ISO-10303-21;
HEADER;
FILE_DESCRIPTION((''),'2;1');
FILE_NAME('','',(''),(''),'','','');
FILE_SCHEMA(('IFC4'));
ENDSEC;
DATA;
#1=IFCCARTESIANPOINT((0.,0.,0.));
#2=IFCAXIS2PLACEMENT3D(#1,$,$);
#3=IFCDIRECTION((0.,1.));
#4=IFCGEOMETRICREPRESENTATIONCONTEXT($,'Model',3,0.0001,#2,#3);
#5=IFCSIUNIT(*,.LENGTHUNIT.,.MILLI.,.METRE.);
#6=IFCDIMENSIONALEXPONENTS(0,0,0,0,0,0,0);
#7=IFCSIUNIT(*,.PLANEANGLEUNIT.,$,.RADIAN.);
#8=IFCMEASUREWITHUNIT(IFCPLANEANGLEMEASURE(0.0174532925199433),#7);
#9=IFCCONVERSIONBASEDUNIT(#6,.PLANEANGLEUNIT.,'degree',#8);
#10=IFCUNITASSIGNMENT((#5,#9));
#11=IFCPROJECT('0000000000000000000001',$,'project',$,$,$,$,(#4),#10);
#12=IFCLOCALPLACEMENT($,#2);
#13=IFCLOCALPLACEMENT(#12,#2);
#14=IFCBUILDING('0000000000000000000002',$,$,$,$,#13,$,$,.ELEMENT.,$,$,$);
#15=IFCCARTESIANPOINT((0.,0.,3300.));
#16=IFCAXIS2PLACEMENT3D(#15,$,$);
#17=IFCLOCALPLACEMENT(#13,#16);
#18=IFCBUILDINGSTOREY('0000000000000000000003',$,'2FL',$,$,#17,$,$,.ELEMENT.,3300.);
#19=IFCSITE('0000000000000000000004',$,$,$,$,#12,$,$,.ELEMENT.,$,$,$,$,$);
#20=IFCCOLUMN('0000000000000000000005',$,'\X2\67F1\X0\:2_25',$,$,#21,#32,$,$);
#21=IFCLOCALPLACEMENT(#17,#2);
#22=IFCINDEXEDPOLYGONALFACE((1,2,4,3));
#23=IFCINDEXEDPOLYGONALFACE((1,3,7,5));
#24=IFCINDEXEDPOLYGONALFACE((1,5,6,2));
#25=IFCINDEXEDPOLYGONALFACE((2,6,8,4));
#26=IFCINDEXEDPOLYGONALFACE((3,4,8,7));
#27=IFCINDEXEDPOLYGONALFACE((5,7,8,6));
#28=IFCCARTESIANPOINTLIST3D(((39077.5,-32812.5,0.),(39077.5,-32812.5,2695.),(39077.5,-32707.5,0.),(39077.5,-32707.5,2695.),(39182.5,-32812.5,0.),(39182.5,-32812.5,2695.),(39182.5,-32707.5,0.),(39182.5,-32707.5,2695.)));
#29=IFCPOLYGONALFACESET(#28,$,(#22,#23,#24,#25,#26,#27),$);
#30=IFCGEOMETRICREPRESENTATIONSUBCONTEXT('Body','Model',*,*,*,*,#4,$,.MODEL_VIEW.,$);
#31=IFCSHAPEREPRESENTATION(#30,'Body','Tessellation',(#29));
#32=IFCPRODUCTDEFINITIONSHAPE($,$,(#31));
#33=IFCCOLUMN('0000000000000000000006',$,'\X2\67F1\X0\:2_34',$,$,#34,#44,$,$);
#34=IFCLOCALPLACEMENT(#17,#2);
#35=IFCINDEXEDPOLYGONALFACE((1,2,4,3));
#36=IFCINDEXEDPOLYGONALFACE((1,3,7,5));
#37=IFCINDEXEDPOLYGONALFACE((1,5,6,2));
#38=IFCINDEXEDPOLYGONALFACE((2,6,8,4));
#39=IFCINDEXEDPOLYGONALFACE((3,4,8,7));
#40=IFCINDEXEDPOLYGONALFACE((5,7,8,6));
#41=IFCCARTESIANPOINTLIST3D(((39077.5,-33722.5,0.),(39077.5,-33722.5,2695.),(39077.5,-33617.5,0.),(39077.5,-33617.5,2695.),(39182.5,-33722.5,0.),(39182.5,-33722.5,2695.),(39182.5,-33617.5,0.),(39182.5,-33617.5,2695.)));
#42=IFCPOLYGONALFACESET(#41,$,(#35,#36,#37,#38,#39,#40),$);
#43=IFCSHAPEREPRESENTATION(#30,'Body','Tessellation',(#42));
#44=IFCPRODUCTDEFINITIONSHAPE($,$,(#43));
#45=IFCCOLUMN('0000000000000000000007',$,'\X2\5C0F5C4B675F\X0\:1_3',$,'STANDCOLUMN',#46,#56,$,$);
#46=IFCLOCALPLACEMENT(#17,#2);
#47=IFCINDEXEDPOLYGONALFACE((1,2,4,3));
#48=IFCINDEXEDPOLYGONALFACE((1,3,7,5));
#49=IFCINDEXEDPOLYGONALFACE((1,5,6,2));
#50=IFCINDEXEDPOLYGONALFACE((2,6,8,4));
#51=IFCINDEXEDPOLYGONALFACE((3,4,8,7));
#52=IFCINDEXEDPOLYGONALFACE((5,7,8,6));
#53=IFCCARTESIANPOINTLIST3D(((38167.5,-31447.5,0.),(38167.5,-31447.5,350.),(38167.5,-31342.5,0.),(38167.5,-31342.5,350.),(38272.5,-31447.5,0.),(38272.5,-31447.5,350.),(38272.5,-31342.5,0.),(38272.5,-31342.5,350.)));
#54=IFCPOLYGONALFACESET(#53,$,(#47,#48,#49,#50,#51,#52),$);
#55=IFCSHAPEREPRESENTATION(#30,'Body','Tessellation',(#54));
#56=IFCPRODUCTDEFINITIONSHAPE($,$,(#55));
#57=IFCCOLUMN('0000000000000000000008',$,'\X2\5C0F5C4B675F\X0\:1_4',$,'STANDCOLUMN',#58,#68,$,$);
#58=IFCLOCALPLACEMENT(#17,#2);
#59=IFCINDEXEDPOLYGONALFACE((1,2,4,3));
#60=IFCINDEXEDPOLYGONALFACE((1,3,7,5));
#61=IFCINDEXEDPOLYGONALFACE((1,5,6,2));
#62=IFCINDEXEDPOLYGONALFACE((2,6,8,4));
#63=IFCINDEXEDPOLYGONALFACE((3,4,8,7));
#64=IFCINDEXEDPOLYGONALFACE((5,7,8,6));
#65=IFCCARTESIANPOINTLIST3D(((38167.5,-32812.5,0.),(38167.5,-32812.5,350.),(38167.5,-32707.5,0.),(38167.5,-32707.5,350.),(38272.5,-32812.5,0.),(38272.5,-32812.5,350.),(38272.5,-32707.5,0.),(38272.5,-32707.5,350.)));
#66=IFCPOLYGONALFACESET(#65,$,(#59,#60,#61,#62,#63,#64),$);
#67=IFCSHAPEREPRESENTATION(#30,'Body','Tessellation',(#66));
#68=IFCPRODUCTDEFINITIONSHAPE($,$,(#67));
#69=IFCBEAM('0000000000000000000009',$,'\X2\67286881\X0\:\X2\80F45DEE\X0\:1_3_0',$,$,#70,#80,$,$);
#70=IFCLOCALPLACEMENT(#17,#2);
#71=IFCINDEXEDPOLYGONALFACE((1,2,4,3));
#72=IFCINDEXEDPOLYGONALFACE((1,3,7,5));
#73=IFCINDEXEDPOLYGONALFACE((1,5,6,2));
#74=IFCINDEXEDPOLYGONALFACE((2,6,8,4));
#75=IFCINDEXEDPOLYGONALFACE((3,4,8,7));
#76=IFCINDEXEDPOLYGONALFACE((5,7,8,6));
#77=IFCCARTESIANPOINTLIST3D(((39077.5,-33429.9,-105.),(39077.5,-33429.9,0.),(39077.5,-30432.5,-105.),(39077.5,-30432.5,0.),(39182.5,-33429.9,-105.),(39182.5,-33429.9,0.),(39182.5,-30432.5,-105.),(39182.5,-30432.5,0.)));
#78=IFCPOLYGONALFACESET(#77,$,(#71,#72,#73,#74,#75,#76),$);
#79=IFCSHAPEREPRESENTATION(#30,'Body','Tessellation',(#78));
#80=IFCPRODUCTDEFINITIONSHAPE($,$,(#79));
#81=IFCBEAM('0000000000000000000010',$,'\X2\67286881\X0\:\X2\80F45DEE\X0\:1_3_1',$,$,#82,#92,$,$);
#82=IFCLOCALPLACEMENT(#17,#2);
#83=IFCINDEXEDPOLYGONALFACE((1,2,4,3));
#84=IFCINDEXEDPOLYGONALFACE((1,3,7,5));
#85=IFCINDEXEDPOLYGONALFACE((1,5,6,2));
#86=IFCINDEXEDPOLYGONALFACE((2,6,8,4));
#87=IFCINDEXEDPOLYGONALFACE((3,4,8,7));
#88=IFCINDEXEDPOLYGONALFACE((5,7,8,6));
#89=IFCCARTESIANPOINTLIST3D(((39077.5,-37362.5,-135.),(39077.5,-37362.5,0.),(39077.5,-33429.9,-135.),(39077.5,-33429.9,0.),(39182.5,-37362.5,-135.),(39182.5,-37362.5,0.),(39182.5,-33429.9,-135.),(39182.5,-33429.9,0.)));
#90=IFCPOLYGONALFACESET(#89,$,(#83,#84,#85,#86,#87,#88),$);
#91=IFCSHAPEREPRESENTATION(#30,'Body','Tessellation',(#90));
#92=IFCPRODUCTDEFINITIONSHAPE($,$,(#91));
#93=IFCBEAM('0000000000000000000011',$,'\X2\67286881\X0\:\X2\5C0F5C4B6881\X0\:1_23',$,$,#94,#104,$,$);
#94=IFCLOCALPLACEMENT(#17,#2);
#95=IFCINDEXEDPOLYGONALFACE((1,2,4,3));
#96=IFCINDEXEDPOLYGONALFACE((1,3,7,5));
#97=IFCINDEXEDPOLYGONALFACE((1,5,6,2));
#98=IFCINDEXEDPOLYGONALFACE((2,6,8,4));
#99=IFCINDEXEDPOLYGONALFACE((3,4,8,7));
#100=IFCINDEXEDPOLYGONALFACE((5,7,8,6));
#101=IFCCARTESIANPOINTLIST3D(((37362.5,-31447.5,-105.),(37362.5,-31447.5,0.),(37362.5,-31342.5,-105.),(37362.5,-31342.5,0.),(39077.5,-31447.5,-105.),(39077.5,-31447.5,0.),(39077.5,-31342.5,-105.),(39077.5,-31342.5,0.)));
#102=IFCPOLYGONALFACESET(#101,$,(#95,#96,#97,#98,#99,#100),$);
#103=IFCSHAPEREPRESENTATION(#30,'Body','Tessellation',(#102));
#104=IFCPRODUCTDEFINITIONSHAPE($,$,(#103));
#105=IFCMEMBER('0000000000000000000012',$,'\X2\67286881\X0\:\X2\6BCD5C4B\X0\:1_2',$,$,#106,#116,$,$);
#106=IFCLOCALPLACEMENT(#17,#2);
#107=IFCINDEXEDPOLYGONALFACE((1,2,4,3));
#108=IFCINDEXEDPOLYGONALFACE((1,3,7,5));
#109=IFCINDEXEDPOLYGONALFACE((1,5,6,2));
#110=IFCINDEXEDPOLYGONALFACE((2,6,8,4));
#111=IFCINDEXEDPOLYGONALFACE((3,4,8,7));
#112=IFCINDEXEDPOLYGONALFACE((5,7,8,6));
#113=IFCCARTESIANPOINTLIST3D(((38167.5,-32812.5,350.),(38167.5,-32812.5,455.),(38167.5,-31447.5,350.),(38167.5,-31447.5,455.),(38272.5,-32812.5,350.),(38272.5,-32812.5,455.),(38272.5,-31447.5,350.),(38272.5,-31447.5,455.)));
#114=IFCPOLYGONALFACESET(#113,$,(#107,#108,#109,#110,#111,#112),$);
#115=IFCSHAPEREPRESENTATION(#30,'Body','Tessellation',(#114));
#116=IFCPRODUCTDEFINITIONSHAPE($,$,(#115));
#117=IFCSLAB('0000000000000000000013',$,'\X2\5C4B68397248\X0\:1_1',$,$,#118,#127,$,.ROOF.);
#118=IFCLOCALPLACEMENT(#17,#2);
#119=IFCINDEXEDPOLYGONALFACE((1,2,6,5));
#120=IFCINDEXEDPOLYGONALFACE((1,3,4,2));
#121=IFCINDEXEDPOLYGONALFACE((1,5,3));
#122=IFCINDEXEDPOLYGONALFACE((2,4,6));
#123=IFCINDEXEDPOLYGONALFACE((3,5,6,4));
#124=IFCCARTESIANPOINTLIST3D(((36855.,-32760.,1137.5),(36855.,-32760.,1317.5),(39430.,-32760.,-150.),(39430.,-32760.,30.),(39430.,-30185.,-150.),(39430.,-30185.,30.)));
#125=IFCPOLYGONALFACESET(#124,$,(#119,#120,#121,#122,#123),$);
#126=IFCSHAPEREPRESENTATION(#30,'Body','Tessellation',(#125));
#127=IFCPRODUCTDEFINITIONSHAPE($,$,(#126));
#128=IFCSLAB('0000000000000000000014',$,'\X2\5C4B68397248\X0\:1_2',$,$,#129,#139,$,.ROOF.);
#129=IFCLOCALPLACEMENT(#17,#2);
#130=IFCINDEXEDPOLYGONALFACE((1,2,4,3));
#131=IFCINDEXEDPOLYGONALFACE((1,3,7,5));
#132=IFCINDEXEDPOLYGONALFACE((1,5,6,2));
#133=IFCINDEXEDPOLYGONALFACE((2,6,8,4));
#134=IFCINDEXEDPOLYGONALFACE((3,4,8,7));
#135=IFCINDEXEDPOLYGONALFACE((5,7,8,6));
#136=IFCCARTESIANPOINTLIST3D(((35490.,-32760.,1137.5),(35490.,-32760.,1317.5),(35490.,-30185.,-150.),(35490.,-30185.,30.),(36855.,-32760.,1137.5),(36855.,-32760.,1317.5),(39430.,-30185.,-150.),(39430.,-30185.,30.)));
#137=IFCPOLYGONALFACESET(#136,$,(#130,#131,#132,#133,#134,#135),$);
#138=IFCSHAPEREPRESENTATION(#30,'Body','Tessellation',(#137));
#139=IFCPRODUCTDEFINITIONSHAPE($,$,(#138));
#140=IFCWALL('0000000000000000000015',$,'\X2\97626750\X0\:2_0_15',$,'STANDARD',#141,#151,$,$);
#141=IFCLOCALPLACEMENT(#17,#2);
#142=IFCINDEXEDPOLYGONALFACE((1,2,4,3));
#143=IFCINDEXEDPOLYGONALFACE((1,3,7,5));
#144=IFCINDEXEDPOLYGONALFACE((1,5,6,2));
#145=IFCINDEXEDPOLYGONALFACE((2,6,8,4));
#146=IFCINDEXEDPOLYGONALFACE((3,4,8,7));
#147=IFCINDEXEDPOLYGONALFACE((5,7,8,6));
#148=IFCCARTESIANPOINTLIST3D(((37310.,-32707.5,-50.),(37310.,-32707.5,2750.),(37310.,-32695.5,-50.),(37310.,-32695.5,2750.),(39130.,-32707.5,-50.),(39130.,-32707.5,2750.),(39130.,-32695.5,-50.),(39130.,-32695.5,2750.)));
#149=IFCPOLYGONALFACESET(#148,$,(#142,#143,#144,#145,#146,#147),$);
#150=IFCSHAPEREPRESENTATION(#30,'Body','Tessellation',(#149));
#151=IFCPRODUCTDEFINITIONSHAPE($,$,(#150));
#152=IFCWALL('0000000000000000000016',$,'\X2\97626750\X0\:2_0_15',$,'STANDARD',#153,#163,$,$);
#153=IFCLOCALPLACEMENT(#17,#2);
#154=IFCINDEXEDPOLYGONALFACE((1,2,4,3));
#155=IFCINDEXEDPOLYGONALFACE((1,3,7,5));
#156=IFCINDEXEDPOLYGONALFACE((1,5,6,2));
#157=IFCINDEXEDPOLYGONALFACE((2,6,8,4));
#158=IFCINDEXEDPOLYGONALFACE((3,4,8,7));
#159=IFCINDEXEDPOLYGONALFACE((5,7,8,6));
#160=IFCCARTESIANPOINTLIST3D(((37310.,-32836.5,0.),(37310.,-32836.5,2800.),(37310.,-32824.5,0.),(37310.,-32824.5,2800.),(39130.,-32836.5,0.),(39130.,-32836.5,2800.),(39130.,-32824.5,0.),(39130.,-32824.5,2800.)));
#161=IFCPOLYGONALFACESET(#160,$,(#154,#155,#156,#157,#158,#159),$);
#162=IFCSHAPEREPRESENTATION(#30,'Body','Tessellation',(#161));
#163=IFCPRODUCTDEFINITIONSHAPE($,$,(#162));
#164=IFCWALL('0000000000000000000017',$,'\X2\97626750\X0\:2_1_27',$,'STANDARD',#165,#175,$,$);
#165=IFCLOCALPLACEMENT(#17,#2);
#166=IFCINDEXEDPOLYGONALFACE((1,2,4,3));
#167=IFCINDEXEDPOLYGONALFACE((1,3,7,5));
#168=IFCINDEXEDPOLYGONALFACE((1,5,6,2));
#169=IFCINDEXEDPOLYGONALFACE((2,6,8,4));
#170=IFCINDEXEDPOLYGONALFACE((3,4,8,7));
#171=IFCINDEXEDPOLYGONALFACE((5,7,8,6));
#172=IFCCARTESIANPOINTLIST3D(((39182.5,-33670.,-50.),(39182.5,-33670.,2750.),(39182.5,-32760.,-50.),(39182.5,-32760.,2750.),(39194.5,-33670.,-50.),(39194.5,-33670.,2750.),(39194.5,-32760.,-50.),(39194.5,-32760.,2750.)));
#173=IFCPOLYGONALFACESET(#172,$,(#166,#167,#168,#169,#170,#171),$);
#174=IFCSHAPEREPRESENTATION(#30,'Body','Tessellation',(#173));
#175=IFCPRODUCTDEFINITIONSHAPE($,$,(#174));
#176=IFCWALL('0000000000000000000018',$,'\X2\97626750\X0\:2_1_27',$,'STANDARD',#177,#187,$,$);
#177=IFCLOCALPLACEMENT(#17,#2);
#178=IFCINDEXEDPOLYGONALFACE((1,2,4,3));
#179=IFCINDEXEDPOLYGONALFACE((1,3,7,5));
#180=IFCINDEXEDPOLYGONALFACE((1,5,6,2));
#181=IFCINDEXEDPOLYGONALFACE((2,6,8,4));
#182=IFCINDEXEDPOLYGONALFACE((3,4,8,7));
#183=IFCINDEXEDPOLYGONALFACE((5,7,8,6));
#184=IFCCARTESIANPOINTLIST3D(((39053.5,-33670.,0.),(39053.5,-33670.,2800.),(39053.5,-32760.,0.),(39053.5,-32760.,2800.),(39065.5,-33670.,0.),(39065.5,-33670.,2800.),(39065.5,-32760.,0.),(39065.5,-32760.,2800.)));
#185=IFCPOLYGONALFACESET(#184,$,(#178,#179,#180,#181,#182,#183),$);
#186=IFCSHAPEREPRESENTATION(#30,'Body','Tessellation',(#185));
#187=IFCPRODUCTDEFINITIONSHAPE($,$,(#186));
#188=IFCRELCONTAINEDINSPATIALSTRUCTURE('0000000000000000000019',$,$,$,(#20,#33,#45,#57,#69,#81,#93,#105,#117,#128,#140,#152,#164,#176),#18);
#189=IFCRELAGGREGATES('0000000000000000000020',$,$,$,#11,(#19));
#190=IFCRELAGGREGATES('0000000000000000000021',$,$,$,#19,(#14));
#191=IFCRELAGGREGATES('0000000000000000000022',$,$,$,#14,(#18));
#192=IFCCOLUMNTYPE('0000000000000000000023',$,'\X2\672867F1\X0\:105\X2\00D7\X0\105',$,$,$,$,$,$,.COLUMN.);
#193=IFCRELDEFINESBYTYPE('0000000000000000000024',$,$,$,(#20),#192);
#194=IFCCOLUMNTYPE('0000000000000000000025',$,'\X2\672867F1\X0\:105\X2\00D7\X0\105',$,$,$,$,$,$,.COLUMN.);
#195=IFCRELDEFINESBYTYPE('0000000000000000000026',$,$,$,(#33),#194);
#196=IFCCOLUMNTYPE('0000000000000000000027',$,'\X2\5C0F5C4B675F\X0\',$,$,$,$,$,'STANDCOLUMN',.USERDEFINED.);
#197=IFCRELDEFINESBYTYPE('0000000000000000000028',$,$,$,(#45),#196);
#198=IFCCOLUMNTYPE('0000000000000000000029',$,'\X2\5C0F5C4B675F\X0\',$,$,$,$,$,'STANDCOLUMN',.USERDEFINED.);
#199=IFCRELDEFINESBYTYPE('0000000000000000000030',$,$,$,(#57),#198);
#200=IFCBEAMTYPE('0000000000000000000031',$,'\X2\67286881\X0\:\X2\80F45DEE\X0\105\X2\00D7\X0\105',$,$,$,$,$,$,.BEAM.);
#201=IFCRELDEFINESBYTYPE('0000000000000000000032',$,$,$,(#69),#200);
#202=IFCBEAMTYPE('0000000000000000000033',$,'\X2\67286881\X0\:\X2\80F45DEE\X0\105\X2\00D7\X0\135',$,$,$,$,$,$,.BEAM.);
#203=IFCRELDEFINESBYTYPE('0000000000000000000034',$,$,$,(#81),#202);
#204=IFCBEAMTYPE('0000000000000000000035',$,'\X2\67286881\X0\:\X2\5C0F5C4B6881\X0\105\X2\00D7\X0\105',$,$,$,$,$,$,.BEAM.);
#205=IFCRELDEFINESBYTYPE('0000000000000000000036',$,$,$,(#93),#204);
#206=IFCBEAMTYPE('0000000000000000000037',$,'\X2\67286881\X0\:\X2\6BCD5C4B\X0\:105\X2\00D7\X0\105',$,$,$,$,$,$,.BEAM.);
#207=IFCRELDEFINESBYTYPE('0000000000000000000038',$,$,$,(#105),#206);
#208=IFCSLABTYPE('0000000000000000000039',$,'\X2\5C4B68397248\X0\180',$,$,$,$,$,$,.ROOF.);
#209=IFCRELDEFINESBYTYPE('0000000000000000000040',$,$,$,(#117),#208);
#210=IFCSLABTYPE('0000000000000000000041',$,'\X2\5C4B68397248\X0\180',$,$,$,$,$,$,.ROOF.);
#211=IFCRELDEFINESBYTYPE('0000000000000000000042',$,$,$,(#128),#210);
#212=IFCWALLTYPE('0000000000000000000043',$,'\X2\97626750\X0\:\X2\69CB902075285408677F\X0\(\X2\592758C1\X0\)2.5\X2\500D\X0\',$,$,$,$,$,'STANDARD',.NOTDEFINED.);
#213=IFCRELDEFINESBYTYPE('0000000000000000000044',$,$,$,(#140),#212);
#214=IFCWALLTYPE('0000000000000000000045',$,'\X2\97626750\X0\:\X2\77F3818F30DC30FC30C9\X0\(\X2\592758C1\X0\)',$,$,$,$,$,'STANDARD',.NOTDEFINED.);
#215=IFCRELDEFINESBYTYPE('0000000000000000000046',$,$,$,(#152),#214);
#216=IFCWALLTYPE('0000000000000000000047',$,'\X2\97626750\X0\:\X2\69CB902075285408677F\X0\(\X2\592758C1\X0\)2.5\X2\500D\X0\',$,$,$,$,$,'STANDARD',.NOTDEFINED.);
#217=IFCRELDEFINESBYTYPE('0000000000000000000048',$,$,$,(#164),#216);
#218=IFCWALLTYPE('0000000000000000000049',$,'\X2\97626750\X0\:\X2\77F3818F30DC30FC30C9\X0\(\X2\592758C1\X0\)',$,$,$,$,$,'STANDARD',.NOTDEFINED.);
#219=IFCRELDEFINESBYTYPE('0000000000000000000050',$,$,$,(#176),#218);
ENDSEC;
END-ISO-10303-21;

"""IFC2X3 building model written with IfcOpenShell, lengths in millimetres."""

from ifc_helpers import new_model, entity, si_unit, converted_unit, direction, frame, origin, origin_with_axes, origin_2d, place, context, subcontext, project, spatial, polyline, rectangle, outline, extrude, type_object, element, save


model = new_model("IFC2X3")

# Units and contexts
model_context = context("Model", 3, precision=0.0001, world=origin(), true_north=direction((0.0, 1.0)))
body_context = subcontext(model_context, "Body", "Model", "MODEL_VIEW")
ifc_project = project(units=[si_unit("LENGTHUNIT", "METRE", prefix="MILLI"), converted_unit("PLANEANGLEUNIT", "degree", entity("IfcPlaneAngleMeasure", 0.0174532925199433), si_unit("PLANEANGLEUNIT", "RADIAN"), dimensions=[0, 0, 0, 0, 0, 0, 0])], contexts=[model_context])

# Site, building, storey
site_placement = place(None, origin())
site = spatial("IfcSite", under=ifc_project, at=site_placement, CompositionType="ELEMENT")
building_placement = place(site_placement, origin())
building = spatial("IfcBuilding", under=site, at=building_placement, CompositionType="ELEMENT")
storey_placement = place(building_placement, frame((0.0, 0.0, 3300.0)))
storey = spatial("IfcBuildingStorey", under=building, at=storey_placement, Name="2FL", CompositionType="ELEMENT", Elevation=3300.0)

# Columns
column_type_1 = type_object("IfcColumnType", Name="木柱:105×105", PredefinedType="COLUMN")
column_1_placement = place(storey_placement, frame((39130.0, -32760.0, 0.0)))
element("IfcColumn", 1, at=column_1_placement, inside=storey, type_object=column_type_1, Name="柱:2_25", context=body_context, shape_type="SweptSolid", body=[
    extrude(rectangle(XDim=105.0, YDim=105.0, at=origin_2d()), origin_with_axes(), (0.0, 0.0, 1.0), 2695.0),
])
column_type_2 = type_object("IfcColumnType", Name="木柱:105×105", PredefinedType="COLUMN")
column_2_placement = place(storey_placement, frame((39130.0, -33670.0, 0.0)))
element("IfcColumn", 2, at=column_2_placement, inside=storey, type_object=column_type_2, Name="柱:2_34", context=body_context, shape_type="SweptSolid", body=[
    extrude(rectangle(XDim=105.0, YDim=105.0, at=origin_2d()), origin_with_axes(), (0.0, 0.0, 1.0), 2695.0),
])
column_type_3 = type_object("IfcColumnType", Name="小屋束", ElementType="STANDCOLUMN", PredefinedType="USERDEFINED")
column_3_placement = place(storey_placement, frame((38220.0, -31395.0, 0.0)))
element("IfcColumn", 3, at=column_3_placement, inside=storey, type_object=column_type_3, Name="小屋束:1_3", ObjectType="STANDCOLUMN", context=body_context, shape_type="SweptSolid", body=[
    extrude(rectangle(XDim=105.0, YDim=105.0, at=origin_2d()), origin_with_axes(), (0.0, 0.0, 1.0), 350.0),
])
column_type_4 = type_object("IfcColumnType", Name="小屋束", ElementType="STANDCOLUMN", PredefinedType="USERDEFINED")
column_4_placement = place(storey_placement, frame((38220.0, -32760.0, 0.0)))
element("IfcColumn", 4, at=column_4_placement, inside=storey, type_object=column_type_4, Name="小屋束:1_4", ObjectType="STANDCOLUMN", context=body_context, shape_type="SweptSolid", body=[
    extrude(rectangle(XDim=105.0, YDim=105.0, at=origin_2d()), origin_with_axes(), (0.0, 0.0, 1.0), 350.0),
])

# Beams
beam_type_1 = type_object("IfcBeamType", Name="木梁:胴差105×105", PredefinedType="BEAM")
beam_1_placement = place(storey_placement, frame((39130.0, -30432.5, -52.5), z_axis=(0.0, -1.0, 0.0), x_axis=(1.0, 0.0, 0.0)))
element("IfcBeam", 5, at=beam_1_placement, inside=storey, type_object=beam_type_1, Name="木梁:胴差:1_3_0", context=body_context, shape_type="SweptSolid", body=[
    extrude(rectangle(XDim=105.0, YDim=105.0, at=origin_2d()), origin_with_axes(), (0.0, 0.0, 1.0), 2997.4),
])
beam_type_2 = type_object("IfcBeamType", Name="木梁:胴差105×135", PredefinedType="BEAM")
beam_2_placement = place(storey_placement, frame((39130.0, -33429.9, -67.5), z_axis=(0.0, -1.0, 0.0), x_axis=(1.0, 0.0, 0.0)))
element("IfcBeam", 6, at=beam_2_placement, inside=storey, type_object=beam_type_2, Name="木梁:胴差:1_3_1", context=body_context, shape_type="SweptSolid", body=[
    extrude(rectangle(XDim=105.0, YDim=135.0, at=origin_2d()), origin_with_axes(), (0.0, 0.0, 1.0), 3932.6),
])
beam_type_3 = type_object("IfcBeamType", Name="木梁:小屋梁105×105", PredefinedType="BEAM")
beam_3_placement = place(storey_placement, frame((37362.5, -31395.0, -52.5), z_axis=(1.0, 0.0, 0.0), x_axis=(0.0, 1.0, 0.0)))
element("IfcBeam", 7, at=beam_3_placement, inside=storey, type_object=beam_type_3, Name="木梁:小屋梁:1_23", context=body_context, shape_type="SweptSolid", body=[
    extrude(rectangle(XDim=105.0, YDim=105.0, at=origin_2d()), origin_with_axes(), (0.0, 0.0, 1.0), 1715.0),
])

# Member
beam_type_4 = type_object("IfcBeamType", Name="木梁:母屋:105×105", PredefinedType="BEAM")
member_1_placement = place(storey_placement, frame((38220.0, -31447.5, 402.5), z_axis=(0.0, -1.0, 0.0), x_axis=(-1.0, 0.0, 0.0)))
element("IfcMember", 8, at=member_1_placement, inside=storey, type_object=beam_type_4, Name="木梁:母屋:1_2", context=body_context, shape_type="SweptSolid", body=[
    extrude(rectangle(XDim=105.0, YDim=105.0, at=origin_2d()), origin_with_axes(), (0.0, 0.0, 1.0), 1365.0),
])

# Slabs
slab_type_1 = type_object("IfcSlabType", Name="屋根版180", PredefinedType="ROOF")
slab_1_placement = place(storey_placement, frame((39430.0, -32760.0, -150.0), z_axis=(0.447214, 0.0, 0.894427), x_axis=(0.0, 1.0, 0.0)))
element("IfcSlab", 9, at=slab_1_placement, inside=storey, type_object=slab_type_1, Name="屋根版:1_1", PredefinedType="ROOF", context=body_context, shape_type="SweptSolid", body=[
    extrude(outline(polyline([(0.0, 0.0, 0.0), (2575.0, 0.0, 0.0), (0.0, 2878.9, 0.0), (0.0, 0.0, 0.0)])), origin_with_axes(), (0.0, 0.447214, 0.894427), 180.0),
])
slab_type_2 = type_object("IfcSlabType", Name="屋根版180", PredefinedType="ROOF")
slab_2_placement = place(storey_placement, frame((39430.0, -30185.0, -150.0), z_axis=(0.0, -0.447214, -0.894427), x_axis=(-0.666667, -0.666667, 0.333333)))
element("IfcSlab", 10, at=slab_2_placement, inside=storey, type_object=slab_type_2, Name="屋根版:1_2", PredefinedType="ROOF", context=body_context, shape_type="SweptSolid", body=[
    extrude(outline(polyline([(0.0, 0.0, 0.0), (3862.5, 0.0, 0.0), (4772.5, 1017.4, 0.0), (2626.7, 2936.7, 0.0), (0.0, 0.0, 0.0)])), origin_with_axes(), (0.333333, -0.298142, -0.894427), 180.0),
])

# Walls
wall_type_1 = type_object("IfcWallType", Name="面材:構造用合板(大壁)2.5倍", ElementType="STANDARD", PredefinedType="NOTDEFINED")
wall_1_placement = place(storey_placement, frame((38220.0, -32695.5, -50.0), z_axis=(0.0, -1.0, 0.0), x_axis=(1.0, 0.0, 0.0)))
element("IfcWall", 11, at=wall_1_placement, inside=storey, type_object=wall_type_1, Name="面材:2_0_15", ObjectType="STANDARD", context=body_context, shape_type="SweptSolid", body=[
    extrude(outline(polyline([(910.0, 0.0, 0.0), (-910.0, 0.0, 0.0), (-910.0, 2800.0, 0.0), (910.0, 2800.0, 0.0), (910.0, 0.0, 0.0)])), origin_with_axes(), (0.0, 0.0, 1.0), 12.0),
])
wall_type_2 = type_object("IfcWallType", Name="面材:石膏ボード(大壁)", ElementType="STANDARD", PredefinedType="NOTDEFINED")
wall_2_placement = place(storey_placement, frame((38220.0, -32824.5, 0.0), z_axis=(0.0, -1.0, 0.0), x_axis=(1.0, 0.0, 0.0)))
element("IfcWall", 12, at=wall_2_placement, inside=storey, type_object=wall_type_2, Name="面材:2_0_15", ObjectType="STANDARD", context=body_context, shape_type="SweptSolid", body=[
    extrude(outline(polyline([(910.0, 0.0, 0.0), (-910.0, 0.0, 0.0), (-910.0, 2800.0, 0.0), (910.0, 2800.0, 0.0), (910.0, 0.0, 0.0)])), origin_with_axes(), (0.0, 0.0, 1.0), 12.0),
])
wall_type_3 = type_object("IfcWallType", Name="面材:構造用合板(大壁)2.5倍", ElementType="STANDARD", PredefinedType="NOTDEFINED")
wall_3_placement = place(storey_placement, frame((39194.5, -33215.0, -50.0), z_axis=(-1.0, 0.0, 0.0), x_axis=(0.0, -1.0, 0.0)))
element("IfcWall", 13, at=wall_3_placement, inside=storey, type_object=wall_type_3, Name="面材:2_1_27", ObjectType="STANDARD", context=body_context, shape_type="SweptSolid", body=[
    extrude(outline(polyline([(455.0, 0.0, 0.0), (-455.0, 0.0, 0.0), (-455.0, 2800.0, 0.0), (455.0, 2800.0, 0.0), (455.0, 0.0, 0.0)])), origin_with_axes(), (0.0, 0.0, 1.0), 12.0),
])
wall_type_4 = type_object("IfcWallType", Name="面材:石膏ボード(大壁)", ElementType="STANDARD", PredefinedType="NOTDEFINED")
wall_4_placement = place(storey_placement, frame((39065.5, -33215.0, 0.0), z_axis=(-1.0, 0.0, 0.0), x_axis=(0.0, -1.0, 0.0)))
element("IfcWall", 14, at=wall_4_placement, inside=storey, type_object=wall_type_4, Name="面材:2_1_27", ObjectType="STANDARD", context=body_context, shape_type="SweptSolid", body=[
    extrude(outline(polyline([(455.0, 0.0, 0.0), (-455.0, 0.0, 0.0), (-455.0, 2800.0, 0.0), (455.0, 2800.0, 0.0), (455.0, 0.0, 0.0)])), origin_with_axes(), (0.0, 0.0, 1.0), 12.0),
])

save(model, "model.ifc")
